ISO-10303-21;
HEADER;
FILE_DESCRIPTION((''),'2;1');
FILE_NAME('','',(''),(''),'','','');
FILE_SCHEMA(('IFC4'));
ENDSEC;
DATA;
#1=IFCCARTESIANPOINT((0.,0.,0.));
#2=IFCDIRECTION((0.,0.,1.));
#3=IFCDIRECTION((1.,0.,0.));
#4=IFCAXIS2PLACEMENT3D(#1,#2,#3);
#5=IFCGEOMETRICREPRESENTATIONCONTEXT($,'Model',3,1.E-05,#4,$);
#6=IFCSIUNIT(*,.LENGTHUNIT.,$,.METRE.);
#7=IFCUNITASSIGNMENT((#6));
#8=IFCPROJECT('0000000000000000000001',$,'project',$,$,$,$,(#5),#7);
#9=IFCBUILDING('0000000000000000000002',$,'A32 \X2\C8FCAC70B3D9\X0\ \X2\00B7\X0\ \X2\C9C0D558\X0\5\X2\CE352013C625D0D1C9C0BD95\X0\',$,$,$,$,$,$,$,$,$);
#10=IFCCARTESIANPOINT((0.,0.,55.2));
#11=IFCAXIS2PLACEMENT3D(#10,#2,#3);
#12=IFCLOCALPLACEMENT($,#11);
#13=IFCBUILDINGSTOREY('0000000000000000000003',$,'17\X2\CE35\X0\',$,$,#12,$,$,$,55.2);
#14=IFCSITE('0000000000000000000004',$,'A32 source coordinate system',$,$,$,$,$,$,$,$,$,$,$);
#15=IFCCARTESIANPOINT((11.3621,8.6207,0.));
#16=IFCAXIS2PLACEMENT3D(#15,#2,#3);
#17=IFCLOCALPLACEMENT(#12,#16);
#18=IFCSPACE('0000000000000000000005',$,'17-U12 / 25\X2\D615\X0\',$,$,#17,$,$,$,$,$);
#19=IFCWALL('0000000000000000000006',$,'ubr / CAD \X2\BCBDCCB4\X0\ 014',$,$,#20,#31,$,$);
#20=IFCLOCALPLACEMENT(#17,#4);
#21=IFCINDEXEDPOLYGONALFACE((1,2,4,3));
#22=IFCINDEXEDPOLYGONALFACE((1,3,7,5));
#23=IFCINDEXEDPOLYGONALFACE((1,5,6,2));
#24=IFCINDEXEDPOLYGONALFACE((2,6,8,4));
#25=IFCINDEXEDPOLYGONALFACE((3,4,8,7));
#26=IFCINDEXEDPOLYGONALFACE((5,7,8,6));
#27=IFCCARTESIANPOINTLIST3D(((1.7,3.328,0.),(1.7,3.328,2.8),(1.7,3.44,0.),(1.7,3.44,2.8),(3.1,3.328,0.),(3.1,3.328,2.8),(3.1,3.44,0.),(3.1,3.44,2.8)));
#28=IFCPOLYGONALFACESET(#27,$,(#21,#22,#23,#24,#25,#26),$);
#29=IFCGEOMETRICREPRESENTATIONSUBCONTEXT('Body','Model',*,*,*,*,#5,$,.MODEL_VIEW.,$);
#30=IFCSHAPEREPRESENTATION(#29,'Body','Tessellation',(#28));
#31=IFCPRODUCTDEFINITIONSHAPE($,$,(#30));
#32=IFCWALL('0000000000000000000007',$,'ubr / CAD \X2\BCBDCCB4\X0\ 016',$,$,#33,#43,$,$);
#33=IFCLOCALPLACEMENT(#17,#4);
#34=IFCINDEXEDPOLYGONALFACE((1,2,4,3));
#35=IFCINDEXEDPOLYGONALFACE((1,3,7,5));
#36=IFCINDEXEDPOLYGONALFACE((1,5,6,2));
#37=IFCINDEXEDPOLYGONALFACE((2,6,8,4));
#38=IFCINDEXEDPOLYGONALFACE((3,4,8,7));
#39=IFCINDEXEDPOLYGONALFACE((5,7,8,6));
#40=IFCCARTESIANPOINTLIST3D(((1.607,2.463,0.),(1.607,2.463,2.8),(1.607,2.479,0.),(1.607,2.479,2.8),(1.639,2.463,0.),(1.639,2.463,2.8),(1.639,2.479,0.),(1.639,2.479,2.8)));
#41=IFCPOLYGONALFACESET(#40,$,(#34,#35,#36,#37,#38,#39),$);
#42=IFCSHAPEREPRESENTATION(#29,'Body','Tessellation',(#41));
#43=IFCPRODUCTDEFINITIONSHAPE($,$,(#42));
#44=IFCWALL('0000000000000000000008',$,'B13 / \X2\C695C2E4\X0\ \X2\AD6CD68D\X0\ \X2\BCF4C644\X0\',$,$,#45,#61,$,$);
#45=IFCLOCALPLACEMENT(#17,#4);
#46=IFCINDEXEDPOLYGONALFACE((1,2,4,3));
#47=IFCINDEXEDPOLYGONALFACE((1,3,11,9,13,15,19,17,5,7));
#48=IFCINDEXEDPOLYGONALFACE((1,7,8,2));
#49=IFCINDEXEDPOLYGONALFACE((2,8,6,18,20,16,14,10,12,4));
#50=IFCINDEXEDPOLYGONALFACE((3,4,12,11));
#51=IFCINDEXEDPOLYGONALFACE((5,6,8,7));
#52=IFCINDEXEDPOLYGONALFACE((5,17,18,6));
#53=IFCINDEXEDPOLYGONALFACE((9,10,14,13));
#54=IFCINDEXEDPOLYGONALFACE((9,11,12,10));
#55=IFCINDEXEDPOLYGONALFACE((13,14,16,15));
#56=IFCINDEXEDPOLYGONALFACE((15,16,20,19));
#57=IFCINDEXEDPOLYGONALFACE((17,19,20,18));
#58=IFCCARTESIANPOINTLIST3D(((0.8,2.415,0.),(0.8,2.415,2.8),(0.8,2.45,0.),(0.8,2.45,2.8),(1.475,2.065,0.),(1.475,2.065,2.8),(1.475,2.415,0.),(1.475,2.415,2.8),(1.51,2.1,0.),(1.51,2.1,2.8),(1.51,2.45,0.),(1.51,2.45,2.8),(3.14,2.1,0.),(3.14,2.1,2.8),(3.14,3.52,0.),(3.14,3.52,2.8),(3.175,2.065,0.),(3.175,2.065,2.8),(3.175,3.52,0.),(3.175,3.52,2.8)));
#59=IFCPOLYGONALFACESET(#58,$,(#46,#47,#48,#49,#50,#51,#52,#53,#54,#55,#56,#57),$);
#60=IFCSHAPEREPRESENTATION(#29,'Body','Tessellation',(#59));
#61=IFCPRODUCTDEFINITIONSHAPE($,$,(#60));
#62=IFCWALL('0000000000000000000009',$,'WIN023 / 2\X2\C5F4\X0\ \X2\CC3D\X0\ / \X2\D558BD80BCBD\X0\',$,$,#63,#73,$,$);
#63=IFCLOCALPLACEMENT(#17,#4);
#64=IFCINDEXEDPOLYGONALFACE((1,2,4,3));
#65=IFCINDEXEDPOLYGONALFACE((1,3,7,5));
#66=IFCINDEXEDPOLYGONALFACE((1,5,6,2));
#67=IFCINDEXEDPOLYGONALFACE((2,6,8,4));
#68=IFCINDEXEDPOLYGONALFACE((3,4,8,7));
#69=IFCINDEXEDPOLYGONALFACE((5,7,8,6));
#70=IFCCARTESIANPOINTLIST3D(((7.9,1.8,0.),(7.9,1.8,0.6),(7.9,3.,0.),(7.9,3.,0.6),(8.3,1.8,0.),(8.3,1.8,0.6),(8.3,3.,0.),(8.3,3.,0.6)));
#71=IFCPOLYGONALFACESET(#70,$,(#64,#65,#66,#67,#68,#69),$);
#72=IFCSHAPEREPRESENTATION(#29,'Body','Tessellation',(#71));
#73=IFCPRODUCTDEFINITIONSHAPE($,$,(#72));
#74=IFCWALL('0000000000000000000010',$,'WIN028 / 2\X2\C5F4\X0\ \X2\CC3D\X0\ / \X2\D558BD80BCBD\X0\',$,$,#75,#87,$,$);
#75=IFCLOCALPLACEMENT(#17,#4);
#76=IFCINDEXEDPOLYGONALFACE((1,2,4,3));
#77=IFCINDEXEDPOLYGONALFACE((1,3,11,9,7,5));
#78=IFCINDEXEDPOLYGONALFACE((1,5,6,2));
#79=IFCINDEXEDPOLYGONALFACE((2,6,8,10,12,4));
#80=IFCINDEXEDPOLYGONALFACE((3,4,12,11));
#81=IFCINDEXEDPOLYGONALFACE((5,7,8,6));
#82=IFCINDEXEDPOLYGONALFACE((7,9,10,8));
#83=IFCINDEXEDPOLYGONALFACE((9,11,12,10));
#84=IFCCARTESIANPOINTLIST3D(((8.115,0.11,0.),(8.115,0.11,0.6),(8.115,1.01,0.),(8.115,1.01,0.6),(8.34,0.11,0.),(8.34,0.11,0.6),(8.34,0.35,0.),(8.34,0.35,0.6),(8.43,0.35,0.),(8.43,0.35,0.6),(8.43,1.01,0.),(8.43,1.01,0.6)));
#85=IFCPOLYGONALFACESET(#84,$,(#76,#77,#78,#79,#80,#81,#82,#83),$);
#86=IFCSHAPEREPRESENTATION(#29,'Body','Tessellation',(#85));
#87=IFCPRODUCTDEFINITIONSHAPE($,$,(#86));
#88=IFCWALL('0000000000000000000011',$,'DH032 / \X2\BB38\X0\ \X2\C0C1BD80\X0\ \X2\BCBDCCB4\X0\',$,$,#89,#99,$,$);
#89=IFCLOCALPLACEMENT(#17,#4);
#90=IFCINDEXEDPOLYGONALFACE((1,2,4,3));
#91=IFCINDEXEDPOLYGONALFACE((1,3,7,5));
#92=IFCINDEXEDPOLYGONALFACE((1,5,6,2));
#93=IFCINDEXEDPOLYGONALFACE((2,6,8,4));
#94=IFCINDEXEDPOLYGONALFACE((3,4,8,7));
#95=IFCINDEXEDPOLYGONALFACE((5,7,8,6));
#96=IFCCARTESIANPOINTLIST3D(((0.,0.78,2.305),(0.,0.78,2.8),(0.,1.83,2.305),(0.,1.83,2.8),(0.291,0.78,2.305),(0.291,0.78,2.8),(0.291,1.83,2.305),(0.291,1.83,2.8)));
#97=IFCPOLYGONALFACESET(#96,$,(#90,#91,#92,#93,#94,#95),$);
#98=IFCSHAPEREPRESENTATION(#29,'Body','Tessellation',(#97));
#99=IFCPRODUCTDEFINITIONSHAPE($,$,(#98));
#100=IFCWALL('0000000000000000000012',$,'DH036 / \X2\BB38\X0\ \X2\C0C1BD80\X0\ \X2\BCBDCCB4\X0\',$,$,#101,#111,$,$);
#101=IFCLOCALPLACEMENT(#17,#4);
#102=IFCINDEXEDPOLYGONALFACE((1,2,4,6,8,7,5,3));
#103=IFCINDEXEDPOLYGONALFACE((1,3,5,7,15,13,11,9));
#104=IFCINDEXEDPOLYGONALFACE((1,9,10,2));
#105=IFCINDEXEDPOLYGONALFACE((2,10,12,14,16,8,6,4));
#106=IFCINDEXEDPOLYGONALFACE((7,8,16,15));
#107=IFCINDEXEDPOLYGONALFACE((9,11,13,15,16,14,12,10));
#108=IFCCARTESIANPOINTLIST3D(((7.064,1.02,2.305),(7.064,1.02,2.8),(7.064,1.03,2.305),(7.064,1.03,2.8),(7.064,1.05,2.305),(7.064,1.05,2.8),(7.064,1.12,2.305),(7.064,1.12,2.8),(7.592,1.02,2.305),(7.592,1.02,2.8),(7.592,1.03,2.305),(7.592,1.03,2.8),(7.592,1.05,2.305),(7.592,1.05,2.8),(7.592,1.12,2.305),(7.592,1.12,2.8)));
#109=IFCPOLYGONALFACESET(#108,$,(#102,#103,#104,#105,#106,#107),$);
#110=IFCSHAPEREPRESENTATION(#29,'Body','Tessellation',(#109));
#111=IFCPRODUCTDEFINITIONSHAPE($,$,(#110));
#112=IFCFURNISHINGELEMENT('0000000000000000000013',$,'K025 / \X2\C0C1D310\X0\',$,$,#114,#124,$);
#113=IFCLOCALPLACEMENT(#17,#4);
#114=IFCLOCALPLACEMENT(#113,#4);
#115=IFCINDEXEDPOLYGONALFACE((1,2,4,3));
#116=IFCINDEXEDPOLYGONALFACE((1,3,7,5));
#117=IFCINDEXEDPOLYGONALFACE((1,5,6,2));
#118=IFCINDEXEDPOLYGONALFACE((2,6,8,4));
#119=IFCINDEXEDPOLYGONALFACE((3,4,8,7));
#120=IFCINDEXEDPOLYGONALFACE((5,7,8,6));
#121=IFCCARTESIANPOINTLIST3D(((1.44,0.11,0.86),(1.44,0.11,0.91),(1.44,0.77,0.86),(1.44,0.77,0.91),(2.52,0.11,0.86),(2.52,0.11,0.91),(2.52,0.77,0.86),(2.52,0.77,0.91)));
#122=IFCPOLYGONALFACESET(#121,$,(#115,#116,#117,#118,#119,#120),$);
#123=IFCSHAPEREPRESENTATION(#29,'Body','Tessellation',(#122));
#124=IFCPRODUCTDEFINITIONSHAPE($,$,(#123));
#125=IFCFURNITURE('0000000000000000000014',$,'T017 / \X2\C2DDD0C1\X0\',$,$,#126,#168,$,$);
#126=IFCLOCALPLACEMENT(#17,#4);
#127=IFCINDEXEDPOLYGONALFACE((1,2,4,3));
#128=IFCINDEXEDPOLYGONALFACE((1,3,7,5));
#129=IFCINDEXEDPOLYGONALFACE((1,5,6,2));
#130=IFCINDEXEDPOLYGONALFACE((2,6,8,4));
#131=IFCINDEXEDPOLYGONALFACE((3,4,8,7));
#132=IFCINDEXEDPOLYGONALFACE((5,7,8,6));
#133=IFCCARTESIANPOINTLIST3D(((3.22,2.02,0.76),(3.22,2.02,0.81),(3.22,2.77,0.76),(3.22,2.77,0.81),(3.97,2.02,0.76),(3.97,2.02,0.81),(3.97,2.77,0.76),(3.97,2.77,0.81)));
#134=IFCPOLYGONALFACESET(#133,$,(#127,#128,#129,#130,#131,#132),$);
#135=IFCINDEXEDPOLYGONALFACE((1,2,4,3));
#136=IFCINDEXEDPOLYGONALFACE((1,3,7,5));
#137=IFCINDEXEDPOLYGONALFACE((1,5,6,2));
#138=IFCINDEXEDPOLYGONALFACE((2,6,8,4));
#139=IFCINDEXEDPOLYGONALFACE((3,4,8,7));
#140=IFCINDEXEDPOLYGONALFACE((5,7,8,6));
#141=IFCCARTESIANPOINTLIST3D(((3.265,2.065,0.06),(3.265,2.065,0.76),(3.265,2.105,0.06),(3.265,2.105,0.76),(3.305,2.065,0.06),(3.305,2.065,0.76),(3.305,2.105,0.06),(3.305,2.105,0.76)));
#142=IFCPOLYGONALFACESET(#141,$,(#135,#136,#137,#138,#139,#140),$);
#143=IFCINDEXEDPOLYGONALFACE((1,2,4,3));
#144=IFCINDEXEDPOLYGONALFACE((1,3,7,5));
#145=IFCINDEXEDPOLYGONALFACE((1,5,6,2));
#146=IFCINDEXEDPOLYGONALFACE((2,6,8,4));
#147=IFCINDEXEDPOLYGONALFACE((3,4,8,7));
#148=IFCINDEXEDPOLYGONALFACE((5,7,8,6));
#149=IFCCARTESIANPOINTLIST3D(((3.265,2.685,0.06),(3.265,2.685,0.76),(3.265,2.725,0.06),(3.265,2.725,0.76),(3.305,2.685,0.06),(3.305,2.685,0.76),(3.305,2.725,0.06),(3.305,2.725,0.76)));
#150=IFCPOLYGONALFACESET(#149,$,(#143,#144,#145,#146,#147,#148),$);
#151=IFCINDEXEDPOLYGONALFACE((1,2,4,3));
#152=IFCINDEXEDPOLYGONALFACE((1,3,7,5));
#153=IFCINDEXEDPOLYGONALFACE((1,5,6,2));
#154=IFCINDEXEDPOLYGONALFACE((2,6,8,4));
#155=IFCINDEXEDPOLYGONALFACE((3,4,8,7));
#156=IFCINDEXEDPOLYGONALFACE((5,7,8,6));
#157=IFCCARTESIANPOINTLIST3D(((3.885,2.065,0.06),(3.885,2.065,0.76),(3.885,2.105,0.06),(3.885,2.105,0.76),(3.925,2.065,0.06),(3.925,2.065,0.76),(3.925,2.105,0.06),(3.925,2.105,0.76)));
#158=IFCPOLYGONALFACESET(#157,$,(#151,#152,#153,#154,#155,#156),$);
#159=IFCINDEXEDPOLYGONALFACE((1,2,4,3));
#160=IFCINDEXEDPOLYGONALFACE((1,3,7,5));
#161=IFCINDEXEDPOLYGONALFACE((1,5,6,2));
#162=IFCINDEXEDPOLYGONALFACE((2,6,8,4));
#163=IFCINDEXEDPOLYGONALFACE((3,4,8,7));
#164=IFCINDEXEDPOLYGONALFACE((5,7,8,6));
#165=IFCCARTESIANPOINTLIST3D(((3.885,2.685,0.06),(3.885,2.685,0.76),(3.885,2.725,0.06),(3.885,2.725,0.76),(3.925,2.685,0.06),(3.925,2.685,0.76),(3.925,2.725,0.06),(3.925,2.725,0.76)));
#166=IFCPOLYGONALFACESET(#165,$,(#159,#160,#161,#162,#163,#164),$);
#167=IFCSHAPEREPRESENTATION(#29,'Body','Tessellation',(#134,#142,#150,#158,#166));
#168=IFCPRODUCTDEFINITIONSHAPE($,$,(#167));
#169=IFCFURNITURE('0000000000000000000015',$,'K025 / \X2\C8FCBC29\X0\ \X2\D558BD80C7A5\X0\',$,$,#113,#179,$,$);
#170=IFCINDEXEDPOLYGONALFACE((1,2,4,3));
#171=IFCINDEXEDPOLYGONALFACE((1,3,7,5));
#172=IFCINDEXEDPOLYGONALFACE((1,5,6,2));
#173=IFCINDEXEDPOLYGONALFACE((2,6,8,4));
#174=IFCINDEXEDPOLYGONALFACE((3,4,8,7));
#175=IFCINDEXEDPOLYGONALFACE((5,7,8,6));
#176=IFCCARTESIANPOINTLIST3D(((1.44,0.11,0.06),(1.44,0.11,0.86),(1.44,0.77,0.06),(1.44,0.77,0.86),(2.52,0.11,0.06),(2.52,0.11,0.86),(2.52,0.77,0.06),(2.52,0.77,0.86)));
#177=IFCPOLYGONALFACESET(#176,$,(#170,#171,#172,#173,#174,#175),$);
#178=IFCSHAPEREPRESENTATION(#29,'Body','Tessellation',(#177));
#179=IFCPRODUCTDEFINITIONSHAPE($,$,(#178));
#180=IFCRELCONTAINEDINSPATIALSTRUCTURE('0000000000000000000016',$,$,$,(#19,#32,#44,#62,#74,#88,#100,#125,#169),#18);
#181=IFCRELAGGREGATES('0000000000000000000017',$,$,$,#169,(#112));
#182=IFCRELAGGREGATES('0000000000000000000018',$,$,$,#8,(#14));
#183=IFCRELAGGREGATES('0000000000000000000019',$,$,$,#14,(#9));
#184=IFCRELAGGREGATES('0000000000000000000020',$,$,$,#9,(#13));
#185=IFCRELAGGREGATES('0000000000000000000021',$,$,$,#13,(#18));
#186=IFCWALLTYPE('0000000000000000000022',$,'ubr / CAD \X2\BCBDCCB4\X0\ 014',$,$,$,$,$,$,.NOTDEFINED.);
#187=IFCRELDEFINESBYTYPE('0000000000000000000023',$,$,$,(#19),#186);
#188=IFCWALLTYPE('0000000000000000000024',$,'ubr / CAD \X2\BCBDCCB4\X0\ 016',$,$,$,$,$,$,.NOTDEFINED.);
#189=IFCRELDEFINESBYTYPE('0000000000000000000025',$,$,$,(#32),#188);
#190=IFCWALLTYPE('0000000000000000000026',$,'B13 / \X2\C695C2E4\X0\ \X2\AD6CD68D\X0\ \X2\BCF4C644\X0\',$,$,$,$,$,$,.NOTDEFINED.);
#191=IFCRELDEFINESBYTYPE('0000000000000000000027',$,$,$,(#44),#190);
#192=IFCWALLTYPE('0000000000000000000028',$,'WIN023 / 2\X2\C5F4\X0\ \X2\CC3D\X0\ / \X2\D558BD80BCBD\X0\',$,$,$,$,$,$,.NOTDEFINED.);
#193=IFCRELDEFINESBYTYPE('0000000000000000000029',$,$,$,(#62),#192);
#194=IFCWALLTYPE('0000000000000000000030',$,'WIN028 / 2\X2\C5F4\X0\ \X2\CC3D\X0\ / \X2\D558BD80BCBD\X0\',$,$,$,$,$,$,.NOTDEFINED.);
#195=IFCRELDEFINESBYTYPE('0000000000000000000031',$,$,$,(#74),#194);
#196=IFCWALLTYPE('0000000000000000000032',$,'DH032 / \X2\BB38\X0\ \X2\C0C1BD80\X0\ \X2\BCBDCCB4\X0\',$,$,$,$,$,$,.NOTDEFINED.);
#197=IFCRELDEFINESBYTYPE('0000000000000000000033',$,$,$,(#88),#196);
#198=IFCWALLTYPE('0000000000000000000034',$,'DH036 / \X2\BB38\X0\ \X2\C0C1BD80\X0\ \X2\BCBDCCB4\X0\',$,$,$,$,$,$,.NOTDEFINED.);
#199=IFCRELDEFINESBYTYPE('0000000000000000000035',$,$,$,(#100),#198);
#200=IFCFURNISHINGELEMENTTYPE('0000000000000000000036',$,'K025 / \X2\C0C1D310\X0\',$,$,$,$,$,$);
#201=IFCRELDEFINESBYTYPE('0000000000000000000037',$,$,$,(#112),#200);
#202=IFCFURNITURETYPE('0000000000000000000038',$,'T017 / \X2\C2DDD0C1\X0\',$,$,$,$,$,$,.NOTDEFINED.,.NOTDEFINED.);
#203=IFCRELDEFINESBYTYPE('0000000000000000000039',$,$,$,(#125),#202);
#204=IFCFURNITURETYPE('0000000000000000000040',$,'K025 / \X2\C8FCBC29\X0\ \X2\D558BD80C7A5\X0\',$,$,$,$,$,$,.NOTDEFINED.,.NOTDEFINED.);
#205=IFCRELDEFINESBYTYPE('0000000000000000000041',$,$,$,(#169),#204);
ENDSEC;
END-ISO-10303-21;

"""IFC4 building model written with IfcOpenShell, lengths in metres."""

from ifc_helpers import new_model, si_unit, frame, origin, origin_with_axes, place, context, subcontext, project, spatial, polyline, outline, extrude, source, transform, mapped, type_object, type_shapes, element, aggregate, save


model = new_model("IFC4")

# Units and contexts
model_context = context("Model", 3, precision=1e-05, world=origin_with_axes())
body_context = subcontext(model_context, "Body", "Model", "MODEL_VIEW")
ifc_project = project(units=[si_unit("LENGTHUNIT", "METRE")], contexts=[model_context])

# Site, building, storey, space
site = spatial("IfcSite", under=ifc_project, Name="A32 source coordinate system")
building = spatial("IfcBuilding", under=site, Name="A32 주거동 · 지하5층–옥탑지붕")
storey_placement = place(None, frame((0.0, 0.0, 55.2), z_axis=(0.0, 0.0, 1.0), x_axis=(1.0, 0.0, 0.0)))
storey = spatial("IfcBuildingStorey", under=building, at=storey_placement, Name="17층", Elevation=55.2)
space_1_placement = place(storey_placement, frame((11.3621, 8.6207, 0.0), z_axis=(0.0, 0.0, 1.0), x_axis=(1.0, 0.0, 0.0)))
space_1 = spatial("IfcSpace", under=storey, at=space_1_placement, Name="17-U12 / 25형")

# Walls
wall_type_1 = type_object("IfcWallType", Name="ubr / CAD 벽체 014", PredefinedType="NOTDEFINED")
shared_shape_1 = source(origin(), body_context, "Body", "SweptSolid", [
    extrude(outline(polyline([(3.1, 3.44), (3.1, 3.328), (1.7, 3.328), (1.7, 3.44), (3.1, 3.44)])), origin(), (0.0, 0.0, 1.0), 2.8),
])
type_shapes(wall_type_1, [shared_shape_1])
wall_1_placement = place(space_1_placement, origin_with_axes())
element("IfcWall", 1, at=wall_1_placement, inside=space_1, type_object=wall_type_1, Name="ubr / CAD 벽체 014", context=body_context, shape_type="MappedRepresentation", body=[
    mapped(shared_shape_1, transform((0.0, 0.0, 0.0), scale=1.0)),
])
wall_type_2 = type_object("IfcWallType", Name="ubr / CAD 벽체 016", PredefinedType="NOTDEFINED")
shared_shape_2 = source(origin(), body_context, "Body", "SweptSolid", [
    extrude(outline(polyline([(1.639, 2.479), (1.639, 2.463), (1.607, 2.463), (1.607, 2.479), (1.639, 2.479)])), origin(), (0.0, 0.0, 1.0), 2.8),
])
type_shapes(wall_type_2, [shared_shape_2])
wall_2_placement = place(space_1_placement, origin_with_axes())
element("IfcWall", 2, at=wall_2_placement, inside=space_1, type_object=wall_type_2, Name="ubr / CAD 벽체 016", context=body_context, shape_type="MappedRepresentation", body=[
    mapped(shared_shape_2, transform((0.0, 0.0, 0.0), scale=1.0)),
])
wall_type_3 = type_object("IfcWallType", Name="B13 / 욕실 구획 보완", PredefinedType="NOTDEFINED")
shared_shape_3 = source(origin(), body_context, "Body", "SweptSolid", [
    extrude(outline(polyline([(0.8, 2.45), (1.51, 2.45), (1.51, 2.1), (3.14, 2.1), (3.14, 3.52), (3.175, 3.52), (3.175, 2.065), (1.475, 2.065), (1.475, 2.415), (0.8, 2.415), (0.8, 2.45)])), origin(), (0.0, 0.0, 1.0), 2.8),
])
type_shapes(wall_type_3, [shared_shape_3])
wall_3_placement = place(space_1_placement, origin_with_axes())
element("IfcWall", 3, at=wall_3_placement, inside=space_1, type_object=wall_type_3, Name="B13 / 욕실 구획 보완", context=body_context, shape_type="MappedRepresentation", body=[
    mapped(shared_shape_3, transform((0.0, 0.0, 0.0), scale=1.0)),
])
wall_type_4 = type_object("IfcWallType", Name="WIN023 / 2열 창 / 하부벽", PredefinedType="NOTDEFINED")
shared_shape_4 = source(origin(), body_context, "Body", "SweptSolid", [
    extrude(outline(polyline([(7.9, 1.8), (7.9, 3.0), (8.3, 3.0), (8.3, 1.8), (7.9, 1.8)])), origin(), (0.0, 0.0, 1.0), 0.6),
])
type_shapes(wall_type_4, [shared_shape_4])
wall_4_placement = place(space_1_placement, origin_with_axes())
element("IfcWall", 4, at=wall_4_placement, inside=space_1, type_object=wall_type_4, Name="WIN023 / 2열 창 / 하부벽", context=body_context, shape_type="MappedRepresentation", body=[
    mapped(shared_shape_4, transform((0.0, 0.0, 0.0), scale=1.0)),
])
wall_type_5 = type_object("IfcWallType", Name="WIN028 / 2열 창 / 하부벽", PredefinedType="NOTDEFINED")
shared_shape_5 = source(origin(), body_context, "Body", "SweptSolid", [
    extrude(outline(polyline([(8.34, 0.35), (8.34, 0.11), (8.115, 0.11), (8.115, 1.01), (8.43, 1.01), (8.43, 0.35), (8.34, 0.35)])), origin(), (0.0, 0.0, 1.0), 0.6),
])
type_shapes(wall_type_5, [shared_shape_5])
wall_5_placement = place(space_1_placement, origin_with_axes())
element("IfcWall", 5, at=wall_5_placement, inside=space_1, type_object=wall_type_5, Name="WIN028 / 2열 창 / 하부벽", context=body_context, shape_type="MappedRepresentation", body=[
    mapped(shared_shape_5, transform((0.0, 0.0, 0.0), scale=1.0)),
])
wall_type_6 = type_object("IfcWallType", Name="DH032 / 문 상부 벽체", PredefinedType="NOTDEFINED")
shared_shape_6 = source(origin(), body_context, "Body", "SweptSolid", [
    extrude(outline(polyline([(0.0, 1.83), (0.291, 1.83), (0.291, 0.78), (0.0, 0.78), (0.0, 1.83)])), frame((0.0, 0.0, 2.305)), (0.0, 0.0, 1.0), 0.495),
])
type_shapes(wall_type_6, [shared_shape_6])
wall_6_placement = place(space_1_placement, origin_with_axes())
element("IfcWall", 6, at=wall_6_placement, inside=space_1, type_object=wall_type_6, Name="DH032 / 문 상부 벽체", context=body_context, shape_type="MappedRepresentation", body=[
    mapped(shared_shape_6, transform((0.0, 0.0, 0.0), scale=1.0)),
])
wall_type_7 = type_object("IfcWallType", Name="DH036 / 문 상부 벽체", PredefinedType="NOTDEFINED")
shared_shape_7 = source(origin(), body_context, "Body", "SweptSolid", [
    extrude(outline(polyline([(7.064, 1.03), (7.064, 1.05), (7.064, 1.12), (7.592, 1.12), (7.592, 1.05), (7.592, 1.03), (7.592, 1.02), (7.064, 1.02), (7.064, 1.03)])), frame((0.0, 0.0, 2.305)), (0.0, 0.0, 1.0), 0.495),
])
type_shapes(wall_type_7, [shared_shape_7])
wall_7_placement = place(space_1_placement, origin_with_axes())
element("IfcWall", 7, at=wall_7_placement, inside=space_1, type_object=wall_type_7, Name="DH036 / 문 상부 벽체", context=body_context, shape_type="MappedRepresentation", body=[
    mapped(shared_shape_7, transform((0.0, 0.0, 0.0), scale=1.0)),
])

# Furnishing element
furnishing_element_type_1 = type_object("IfcFurnishingElementType", Name="K025 / 상판")
shared_shape_8 = source(origin(), body_context, "Body", "SweptSolid", [
    extrude(outline(polyline([(2.52, 0.77), (2.52, 0.11), (1.44, 0.11), (1.44, 0.77), (2.52, 0.77)])), frame((0.0, 0.0, 0.86)), (0.0, 0.0, 1.0), 0.05),
])
type_shapes(furnishing_element_type_1, [shared_shape_8])
furniture_1_placement = place(space_1_placement, origin_with_axes())
furnishing_1_placement = place(furniture_1_placement, origin_with_axes())
furnishing_1 = element("IfcFurnishingElement", 8, at=furnishing_1_placement, type_object=furnishing_element_type_1, Name="K025 / 상판", context=body_context, shape_type="MappedRepresentation", body=[
    mapped(shared_shape_8, transform((0.0, 0.0, 0.0), scale=1.0)),
])

# Furniture
furniture_type_1 = type_object("IfcFurnitureType", Name="T017 / 식탁", AssemblyPlace="NOTDEFINED", PredefinedType="NOTDEFINED")
shared_shape_9 = source(origin(), body_context, "Body", "SweptSolid", [
    extrude(outline(polyline([(3.97, 2.02), (3.22, 2.02), (3.22, 2.77), (3.97, 2.77), (3.97, 2.02)])), frame((0.0, 0.0, 0.76)), (0.0, 0.0, 1.0), 0.05),
    extrude(outline(polyline([(3.265, 2.065), (3.265, 2.105), (3.305, 2.105), (3.305, 2.065), (3.265, 2.065)])), frame((0.0, 0.0, 0.06)), (0.0, 0.0, 1.0), 0.7),
    extrude(outline(polyline([(3.265, 2.685), (3.265, 2.725), (3.305, 2.725), (3.305, 2.685), (3.265, 2.685)])), frame((0.0, 0.0, 0.06)), (0.0, 0.0, 1.0), 0.7),
    extrude(outline(polyline([(3.885, 2.065), (3.885, 2.105), (3.925, 2.105), (3.925, 2.065), (3.885, 2.065)])), frame((0.0, 0.0, 0.06)), (0.0, 0.0, 1.0), 0.7),
    extrude(outline(polyline([(3.885, 2.685), (3.885, 2.725), (3.925, 2.725), (3.925, 2.685), (3.885, 2.685)])), frame((0.0, 0.0, 0.06)), (0.0, 0.0, 1.0), 0.7),
])
type_shapes(furniture_type_1, [shared_shape_9])
furniture_2_placement = place(space_1_placement, origin_with_axes())
element("IfcFurniture", 9, at=furniture_2_placement, inside=space_1, type_object=furniture_type_1, Name="T017 / 식탁", context=body_context, shape_type="MappedRepresentation", body=[
    mapped(shared_shape_9, transform((0.0, 0.0, 0.0), scale=1.0)),
])
furniture_type_2 = type_object("IfcFurnitureType", Name="K025 / 주방 하부장", AssemblyPlace="NOTDEFINED", PredefinedType="NOTDEFINED")
shared_shape_10 = source(origin(), body_context, "Body", "SweptSolid", [
    extrude(outline(polyline([(1.44, 0.77), (2.52, 0.77), (2.52, 0.11), (1.44, 0.11), (1.44, 0.77)])), frame((0.0, 0.0, 0.06)), (0.0, 0.0, 1.0), 0.8),
])
type_shapes(furniture_type_2, [shared_shape_10])
furniture_1 = element("IfcFurniture", 10, at=furniture_1_placement, inside=space_1, type_object=furniture_type_2, Name="K025 / 주방 하부장", context=body_context, shape_type="MappedRepresentation", body=[
    mapped(shared_shape_10, transform((0.0, 0.0, 0.0), scale=1.0)),
])
aggregate(furniture_1, [furnishing_1])

save(model, "model.ifc")
